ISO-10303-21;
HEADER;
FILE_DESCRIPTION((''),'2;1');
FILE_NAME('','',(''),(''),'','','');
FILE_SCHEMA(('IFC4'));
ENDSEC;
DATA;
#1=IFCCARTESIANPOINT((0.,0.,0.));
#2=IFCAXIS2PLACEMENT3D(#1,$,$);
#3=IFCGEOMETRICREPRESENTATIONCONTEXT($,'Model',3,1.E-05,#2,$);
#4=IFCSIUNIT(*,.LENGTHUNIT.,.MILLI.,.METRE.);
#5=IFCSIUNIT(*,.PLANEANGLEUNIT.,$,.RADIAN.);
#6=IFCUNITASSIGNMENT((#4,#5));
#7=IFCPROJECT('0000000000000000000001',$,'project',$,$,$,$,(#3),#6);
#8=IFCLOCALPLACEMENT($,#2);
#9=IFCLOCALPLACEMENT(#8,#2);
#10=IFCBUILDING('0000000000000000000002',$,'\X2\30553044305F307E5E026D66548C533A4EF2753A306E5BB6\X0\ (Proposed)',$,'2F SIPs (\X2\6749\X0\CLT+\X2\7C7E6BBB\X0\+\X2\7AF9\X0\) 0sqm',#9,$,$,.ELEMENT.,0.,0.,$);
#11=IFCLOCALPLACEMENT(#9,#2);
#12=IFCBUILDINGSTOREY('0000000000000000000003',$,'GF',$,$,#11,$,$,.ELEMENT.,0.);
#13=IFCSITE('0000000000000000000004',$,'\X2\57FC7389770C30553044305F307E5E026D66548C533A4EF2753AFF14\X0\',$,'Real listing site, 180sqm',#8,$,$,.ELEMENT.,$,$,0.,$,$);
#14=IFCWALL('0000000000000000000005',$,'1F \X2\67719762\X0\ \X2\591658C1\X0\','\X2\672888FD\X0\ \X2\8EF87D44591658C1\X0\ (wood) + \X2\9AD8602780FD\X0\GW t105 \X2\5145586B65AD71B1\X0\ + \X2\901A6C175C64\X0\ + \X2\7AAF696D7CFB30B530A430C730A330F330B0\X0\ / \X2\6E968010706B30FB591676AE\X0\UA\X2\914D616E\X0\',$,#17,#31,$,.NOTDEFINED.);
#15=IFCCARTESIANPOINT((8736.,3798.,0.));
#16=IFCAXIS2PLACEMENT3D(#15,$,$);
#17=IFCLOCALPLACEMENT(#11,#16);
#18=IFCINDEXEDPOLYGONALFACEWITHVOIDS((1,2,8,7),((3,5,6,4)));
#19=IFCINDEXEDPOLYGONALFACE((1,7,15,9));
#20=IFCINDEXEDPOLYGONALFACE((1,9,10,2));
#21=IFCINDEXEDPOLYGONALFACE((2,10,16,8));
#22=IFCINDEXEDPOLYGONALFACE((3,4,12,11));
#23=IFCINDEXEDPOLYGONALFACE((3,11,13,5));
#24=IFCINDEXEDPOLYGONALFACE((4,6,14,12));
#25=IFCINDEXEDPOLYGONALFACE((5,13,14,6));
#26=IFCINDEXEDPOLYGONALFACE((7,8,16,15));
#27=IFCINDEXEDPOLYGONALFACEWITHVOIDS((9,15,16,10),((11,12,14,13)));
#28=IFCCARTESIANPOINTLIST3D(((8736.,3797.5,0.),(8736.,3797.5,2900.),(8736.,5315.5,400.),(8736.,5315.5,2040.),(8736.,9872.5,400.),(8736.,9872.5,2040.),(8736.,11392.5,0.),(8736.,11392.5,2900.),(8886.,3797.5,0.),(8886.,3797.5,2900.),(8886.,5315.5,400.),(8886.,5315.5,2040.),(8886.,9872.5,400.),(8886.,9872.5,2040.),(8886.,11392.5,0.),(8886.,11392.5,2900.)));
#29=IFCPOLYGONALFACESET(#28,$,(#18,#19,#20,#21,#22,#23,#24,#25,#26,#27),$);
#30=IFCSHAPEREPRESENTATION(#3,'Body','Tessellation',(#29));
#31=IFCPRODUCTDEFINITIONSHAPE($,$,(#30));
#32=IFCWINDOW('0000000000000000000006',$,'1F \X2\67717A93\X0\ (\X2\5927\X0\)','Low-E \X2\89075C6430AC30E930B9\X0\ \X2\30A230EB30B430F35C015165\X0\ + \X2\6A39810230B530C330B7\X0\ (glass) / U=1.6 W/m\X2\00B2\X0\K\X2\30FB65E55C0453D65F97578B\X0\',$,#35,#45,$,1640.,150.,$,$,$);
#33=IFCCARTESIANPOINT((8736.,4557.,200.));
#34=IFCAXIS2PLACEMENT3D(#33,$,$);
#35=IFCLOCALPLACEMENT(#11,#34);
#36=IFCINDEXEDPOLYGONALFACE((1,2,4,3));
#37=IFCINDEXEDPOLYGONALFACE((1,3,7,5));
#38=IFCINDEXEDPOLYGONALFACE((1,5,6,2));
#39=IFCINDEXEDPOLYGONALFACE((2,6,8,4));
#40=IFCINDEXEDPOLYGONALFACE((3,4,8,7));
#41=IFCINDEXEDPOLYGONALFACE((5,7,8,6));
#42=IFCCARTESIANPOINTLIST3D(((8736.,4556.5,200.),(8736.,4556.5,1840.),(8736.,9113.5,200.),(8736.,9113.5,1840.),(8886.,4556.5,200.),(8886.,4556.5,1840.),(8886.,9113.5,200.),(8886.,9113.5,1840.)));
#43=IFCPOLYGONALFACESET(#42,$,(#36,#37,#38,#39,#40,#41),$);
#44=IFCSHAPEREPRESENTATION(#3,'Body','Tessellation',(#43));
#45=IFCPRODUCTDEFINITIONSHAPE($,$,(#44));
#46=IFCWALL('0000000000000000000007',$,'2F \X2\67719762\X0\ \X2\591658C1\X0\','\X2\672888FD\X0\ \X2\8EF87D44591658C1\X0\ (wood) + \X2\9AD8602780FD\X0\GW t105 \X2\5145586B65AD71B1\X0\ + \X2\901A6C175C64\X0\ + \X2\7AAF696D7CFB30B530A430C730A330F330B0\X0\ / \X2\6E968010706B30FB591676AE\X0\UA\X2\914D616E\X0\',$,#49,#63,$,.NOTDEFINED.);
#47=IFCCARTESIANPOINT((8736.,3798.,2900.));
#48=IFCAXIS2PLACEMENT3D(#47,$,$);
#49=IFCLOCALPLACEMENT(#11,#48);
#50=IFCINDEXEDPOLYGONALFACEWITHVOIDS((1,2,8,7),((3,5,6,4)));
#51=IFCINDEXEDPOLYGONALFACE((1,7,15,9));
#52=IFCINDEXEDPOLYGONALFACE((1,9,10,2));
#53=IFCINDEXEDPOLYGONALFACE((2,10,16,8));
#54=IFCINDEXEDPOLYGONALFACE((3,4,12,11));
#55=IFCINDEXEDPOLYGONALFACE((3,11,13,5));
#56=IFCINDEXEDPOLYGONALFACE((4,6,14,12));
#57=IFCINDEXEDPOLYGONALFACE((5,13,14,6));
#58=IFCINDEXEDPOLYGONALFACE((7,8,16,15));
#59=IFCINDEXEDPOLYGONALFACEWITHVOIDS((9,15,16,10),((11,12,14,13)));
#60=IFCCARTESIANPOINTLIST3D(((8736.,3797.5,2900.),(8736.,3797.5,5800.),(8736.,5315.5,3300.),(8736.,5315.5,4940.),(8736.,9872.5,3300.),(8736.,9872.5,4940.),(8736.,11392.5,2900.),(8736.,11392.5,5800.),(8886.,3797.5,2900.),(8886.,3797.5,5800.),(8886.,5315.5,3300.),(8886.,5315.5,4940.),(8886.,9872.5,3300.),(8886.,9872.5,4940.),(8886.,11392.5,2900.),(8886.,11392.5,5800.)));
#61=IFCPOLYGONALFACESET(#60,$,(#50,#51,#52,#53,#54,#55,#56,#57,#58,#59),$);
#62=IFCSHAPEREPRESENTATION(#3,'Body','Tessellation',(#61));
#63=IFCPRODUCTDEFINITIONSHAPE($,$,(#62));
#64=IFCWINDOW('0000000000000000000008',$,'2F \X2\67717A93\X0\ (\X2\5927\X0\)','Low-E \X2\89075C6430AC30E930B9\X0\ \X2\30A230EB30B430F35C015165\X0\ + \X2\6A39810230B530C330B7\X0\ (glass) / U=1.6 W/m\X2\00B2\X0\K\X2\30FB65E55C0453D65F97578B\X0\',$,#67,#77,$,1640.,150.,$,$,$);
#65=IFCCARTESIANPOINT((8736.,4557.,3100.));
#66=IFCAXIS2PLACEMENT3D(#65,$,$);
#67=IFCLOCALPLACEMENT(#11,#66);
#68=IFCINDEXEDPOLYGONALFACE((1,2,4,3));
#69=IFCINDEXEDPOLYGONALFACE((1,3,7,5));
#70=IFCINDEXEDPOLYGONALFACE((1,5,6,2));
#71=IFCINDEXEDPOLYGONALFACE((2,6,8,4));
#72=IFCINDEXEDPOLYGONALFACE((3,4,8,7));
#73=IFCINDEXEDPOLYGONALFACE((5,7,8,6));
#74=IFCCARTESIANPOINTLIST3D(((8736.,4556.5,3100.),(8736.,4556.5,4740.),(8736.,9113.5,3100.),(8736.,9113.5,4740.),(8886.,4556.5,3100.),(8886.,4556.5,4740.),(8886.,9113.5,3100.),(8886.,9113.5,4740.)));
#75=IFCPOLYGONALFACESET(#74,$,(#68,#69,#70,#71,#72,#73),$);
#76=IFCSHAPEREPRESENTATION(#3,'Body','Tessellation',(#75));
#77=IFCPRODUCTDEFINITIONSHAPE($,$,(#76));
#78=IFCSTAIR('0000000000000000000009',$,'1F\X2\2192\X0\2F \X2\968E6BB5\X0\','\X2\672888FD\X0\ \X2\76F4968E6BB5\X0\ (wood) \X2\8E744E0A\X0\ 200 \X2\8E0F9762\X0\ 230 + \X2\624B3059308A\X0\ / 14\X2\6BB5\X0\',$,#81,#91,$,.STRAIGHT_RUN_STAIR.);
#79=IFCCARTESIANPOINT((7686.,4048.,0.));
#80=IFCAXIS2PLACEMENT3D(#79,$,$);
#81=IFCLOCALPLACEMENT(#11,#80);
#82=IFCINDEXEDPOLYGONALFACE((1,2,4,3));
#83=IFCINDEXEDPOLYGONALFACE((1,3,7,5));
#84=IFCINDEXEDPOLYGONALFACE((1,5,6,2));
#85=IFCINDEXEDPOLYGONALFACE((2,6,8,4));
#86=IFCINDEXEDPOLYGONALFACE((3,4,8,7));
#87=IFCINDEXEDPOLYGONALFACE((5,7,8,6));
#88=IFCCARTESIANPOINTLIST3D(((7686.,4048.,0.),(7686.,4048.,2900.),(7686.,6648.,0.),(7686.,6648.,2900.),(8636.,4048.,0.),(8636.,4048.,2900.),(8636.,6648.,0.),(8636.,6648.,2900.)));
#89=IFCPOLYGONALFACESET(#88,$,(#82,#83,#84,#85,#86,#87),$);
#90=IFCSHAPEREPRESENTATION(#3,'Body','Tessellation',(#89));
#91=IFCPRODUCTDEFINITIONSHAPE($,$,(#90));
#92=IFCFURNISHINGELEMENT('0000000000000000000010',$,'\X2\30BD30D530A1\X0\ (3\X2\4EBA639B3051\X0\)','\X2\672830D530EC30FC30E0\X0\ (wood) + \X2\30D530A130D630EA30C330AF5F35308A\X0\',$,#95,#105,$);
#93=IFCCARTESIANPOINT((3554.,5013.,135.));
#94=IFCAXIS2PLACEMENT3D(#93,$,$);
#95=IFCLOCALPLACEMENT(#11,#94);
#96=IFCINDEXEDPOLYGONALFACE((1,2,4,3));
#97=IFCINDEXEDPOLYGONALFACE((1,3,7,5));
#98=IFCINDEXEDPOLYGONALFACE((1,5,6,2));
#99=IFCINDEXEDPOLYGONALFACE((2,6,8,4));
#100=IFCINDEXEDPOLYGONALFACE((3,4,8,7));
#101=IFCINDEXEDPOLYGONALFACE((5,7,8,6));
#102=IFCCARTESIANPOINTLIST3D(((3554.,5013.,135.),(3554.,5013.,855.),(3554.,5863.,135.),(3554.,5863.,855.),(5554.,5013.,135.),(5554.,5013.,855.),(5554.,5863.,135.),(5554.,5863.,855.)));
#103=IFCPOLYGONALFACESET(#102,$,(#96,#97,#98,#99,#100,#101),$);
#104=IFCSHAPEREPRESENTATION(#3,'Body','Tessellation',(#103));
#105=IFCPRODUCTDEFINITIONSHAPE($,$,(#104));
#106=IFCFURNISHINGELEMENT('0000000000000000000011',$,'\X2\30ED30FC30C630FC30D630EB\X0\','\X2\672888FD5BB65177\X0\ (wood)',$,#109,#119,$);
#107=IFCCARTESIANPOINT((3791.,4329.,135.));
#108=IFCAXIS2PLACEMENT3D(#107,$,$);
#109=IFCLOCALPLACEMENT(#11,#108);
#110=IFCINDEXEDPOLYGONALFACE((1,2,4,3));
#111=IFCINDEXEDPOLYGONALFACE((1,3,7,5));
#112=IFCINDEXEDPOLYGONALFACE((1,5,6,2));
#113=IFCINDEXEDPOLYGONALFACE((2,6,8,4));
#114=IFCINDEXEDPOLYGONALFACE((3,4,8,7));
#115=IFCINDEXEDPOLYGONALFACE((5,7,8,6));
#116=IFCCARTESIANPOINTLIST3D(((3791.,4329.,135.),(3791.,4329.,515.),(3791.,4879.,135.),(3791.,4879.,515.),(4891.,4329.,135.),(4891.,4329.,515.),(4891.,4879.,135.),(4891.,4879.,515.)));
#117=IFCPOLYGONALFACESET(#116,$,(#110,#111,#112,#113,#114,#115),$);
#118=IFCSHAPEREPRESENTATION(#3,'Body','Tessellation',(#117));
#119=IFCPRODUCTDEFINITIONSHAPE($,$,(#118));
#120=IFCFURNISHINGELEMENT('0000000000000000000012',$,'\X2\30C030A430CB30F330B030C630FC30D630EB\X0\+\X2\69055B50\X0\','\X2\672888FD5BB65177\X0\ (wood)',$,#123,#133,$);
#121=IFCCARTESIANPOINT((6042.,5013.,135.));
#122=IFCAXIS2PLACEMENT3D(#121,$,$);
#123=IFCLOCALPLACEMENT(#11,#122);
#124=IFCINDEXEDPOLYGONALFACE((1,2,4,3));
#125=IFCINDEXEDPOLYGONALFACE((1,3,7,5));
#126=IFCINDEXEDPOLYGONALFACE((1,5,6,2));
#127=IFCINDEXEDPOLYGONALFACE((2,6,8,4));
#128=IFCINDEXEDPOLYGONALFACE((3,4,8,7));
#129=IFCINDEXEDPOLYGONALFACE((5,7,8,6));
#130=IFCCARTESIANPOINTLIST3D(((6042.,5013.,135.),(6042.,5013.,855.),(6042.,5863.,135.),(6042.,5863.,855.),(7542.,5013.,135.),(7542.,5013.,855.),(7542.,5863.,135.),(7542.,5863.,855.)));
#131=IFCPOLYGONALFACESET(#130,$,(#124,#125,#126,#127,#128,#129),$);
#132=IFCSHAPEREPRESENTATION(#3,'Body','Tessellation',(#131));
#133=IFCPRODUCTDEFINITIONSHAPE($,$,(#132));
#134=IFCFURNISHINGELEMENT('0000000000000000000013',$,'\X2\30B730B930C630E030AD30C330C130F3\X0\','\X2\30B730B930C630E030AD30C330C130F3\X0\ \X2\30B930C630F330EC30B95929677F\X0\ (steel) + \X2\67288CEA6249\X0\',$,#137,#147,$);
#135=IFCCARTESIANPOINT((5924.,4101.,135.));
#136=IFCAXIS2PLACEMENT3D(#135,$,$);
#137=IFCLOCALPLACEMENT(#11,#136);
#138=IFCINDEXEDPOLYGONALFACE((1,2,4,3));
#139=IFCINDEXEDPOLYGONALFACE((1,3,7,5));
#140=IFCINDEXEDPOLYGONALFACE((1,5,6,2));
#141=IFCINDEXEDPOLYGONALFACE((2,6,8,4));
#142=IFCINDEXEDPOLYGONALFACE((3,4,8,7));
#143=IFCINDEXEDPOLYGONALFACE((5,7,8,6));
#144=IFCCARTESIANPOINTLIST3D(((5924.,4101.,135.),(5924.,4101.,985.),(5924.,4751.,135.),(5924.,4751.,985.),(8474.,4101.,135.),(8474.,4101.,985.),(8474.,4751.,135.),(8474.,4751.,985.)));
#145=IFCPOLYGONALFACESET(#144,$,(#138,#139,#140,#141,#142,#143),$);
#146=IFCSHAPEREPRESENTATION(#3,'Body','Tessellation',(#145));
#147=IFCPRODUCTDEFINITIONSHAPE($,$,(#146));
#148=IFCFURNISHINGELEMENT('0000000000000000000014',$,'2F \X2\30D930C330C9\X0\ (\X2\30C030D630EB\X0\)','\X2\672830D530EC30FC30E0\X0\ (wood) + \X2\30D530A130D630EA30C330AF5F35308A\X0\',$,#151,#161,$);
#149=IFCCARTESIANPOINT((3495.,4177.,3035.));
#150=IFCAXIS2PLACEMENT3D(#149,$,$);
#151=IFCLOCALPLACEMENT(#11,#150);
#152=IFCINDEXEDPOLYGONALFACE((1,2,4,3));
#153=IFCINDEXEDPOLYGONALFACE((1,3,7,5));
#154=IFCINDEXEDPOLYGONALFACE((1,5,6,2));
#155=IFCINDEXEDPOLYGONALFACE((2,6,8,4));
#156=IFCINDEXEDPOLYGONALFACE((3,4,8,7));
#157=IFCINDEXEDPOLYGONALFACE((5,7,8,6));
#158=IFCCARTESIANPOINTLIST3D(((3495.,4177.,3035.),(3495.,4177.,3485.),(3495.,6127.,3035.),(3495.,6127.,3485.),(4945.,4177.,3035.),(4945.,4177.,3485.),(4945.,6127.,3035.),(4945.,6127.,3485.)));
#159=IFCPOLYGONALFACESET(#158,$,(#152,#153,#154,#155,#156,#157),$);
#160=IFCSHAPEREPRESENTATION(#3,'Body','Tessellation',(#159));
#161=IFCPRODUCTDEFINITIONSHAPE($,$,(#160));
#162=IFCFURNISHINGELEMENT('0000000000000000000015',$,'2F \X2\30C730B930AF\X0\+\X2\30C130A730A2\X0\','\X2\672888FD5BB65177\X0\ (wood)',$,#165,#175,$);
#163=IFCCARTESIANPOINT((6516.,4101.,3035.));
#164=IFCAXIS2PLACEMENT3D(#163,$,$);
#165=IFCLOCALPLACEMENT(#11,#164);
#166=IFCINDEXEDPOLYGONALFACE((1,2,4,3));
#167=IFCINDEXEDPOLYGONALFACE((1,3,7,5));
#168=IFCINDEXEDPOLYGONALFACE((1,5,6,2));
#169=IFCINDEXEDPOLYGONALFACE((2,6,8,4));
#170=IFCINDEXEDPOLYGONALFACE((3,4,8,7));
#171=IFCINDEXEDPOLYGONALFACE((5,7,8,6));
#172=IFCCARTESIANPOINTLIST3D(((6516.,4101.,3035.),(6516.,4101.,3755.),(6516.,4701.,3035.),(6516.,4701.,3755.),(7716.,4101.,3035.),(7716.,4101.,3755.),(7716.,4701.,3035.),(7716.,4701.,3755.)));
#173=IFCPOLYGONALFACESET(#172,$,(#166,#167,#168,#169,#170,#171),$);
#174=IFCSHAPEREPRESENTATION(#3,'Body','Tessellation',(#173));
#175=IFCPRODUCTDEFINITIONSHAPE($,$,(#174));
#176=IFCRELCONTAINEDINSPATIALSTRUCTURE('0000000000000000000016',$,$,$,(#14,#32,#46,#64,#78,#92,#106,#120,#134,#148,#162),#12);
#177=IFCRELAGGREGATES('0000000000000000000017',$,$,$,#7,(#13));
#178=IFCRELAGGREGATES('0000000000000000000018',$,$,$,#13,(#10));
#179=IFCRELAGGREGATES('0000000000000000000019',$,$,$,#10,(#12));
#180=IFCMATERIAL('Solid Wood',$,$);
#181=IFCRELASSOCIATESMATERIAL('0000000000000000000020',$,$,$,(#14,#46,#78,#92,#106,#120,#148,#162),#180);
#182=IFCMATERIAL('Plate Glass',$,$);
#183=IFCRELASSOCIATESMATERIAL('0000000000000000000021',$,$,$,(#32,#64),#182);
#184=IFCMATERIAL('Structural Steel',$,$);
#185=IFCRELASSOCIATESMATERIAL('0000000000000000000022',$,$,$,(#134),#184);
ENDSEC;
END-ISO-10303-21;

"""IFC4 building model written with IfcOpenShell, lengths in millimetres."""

from ifc_helpers import new_model, si_unit, frame, frame_2d, origin, place, context, project, spatial, rectangle, extrude, material, element, fill, save


model = new_model("IFC4")

# Units and contexts
model_context = context("Model", 3, precision=1e-05, world=origin())
ifc_project = project(units=[si_unit("LENGTHUNIT", "METRE", prefix="MILLI"), si_unit("PLANEANGLEUNIT", "RADIAN")], contexts=[model_context])

# Site, building, storey
site_placement = place(None, origin())
site = spatial("IfcSite", under=ifc_project, at=site_placement, Name="埼玉県さいたま市浦和区仲町４", ObjectType="Real listing site, 180sqm", CompositionType="ELEMENT", RefElevation=0.0)
building_placement = place(site_placement, origin())
building = spatial("IfcBuilding", under=site, at=building_placement, Name="さいたま市浦和区仲町の家 (Proposed)", ObjectType="2F SIPs (杉CLT+籾殻+竹) 0sqm", CompositionType="ELEMENT", ElevationOfRefHeight=0.0, ElevationOfTerrain=0.0)
storey_placement = place(building_placement, origin())
storey = spatial("IfcBuildingStorey", under=building, at=storey_placement, Name="GF", CompositionType="ELEMENT", Elevation=0.0)

# Wall, opening, window
ifc_material_1 = material(Name="Solid Wood")
wall_1_placement = place(storey_placement, frame((8736.0, 3798.0, 0.0)))
wall_1 = element("IfcWall", 1, at=wall_1_placement, inside=storey, material=ifc_material_1, Name="1F 東面 外壁", Description="木製 軸組外壁 (wood) + 高性能GW t105 充填断熱 + 通気層 + 窯業系サイディング / 準耐火・外皮UA配慮", PredefinedType="NOTDEFINED", context=model_context, shape_type="SweptSolid", body=[
    extrude(rectangle(XDim=150.0, YDim=7595.0, at=frame_2d((75.0, 3797.0))), frame((8736.0, 3798.0, 0.0)), (0.0, 0.0, 1.0), 2900.0),
])
opening_1_placement = place(storey_placement, frame((8736.0, 4557.0, 200.0)))
opening_1 = element("IfcOpeningElement", 2, at=opening_1_placement, cuts=wall_1, PredefinedType="NOTDEFINED", context=model_context, shape_type="SweptSolid", body=[
    extrude(rectangle(XDim=150.0, YDim=4557.0, at=frame_2d((75.0, 2278.0))), frame((8736.0, 4557.0, 200.0)), (0.0, 0.0, 1.0), 1640.0),
])
ifc_material_2 = material(Name="Plate Glass")
window_1_placement = place(storey_placement, frame((8736.0, 4557.0, 200.0)))
window_1 = element("IfcWindow", 3, at=window_1_placement, inside=storey, material=ifc_material_2, Name="1F 東窓 (大)", Description="Low-E 複層ガラス アルゴン封入 + 樹脂サッシ (glass) / U=1.6 W/m²K・日射取得型", OverallHeight=1640.0, OverallWidth=150.0, context=model_context, shape_type="SweptSolid", body=[
    extrude(rectangle(XDim=150.0, YDim=4557.0, at=frame_2d((75.0, 2278.0))), frame((8736.0, 4557.0, 200.0)), (0.0, 0.0, 1.0), 1640.0),
])
fill(opening_1, window_1)

# Wall, opening, window
wall_2_placement = place(storey_placement, frame((8736.0, 3798.0, 2900.0)))
wall_2 = element("IfcWall", 4, at=wall_2_placement, inside=storey, material=ifc_material_1, Name="2F 東面 外壁", Description="木製 軸組外壁 (wood) + 高性能GW t105 充填断熱 + 通気層 + 窯業系サイディング / 準耐火・外皮UA配慮", PredefinedType="NOTDEFINED", context=model_context, shape_type="SweptSolid", body=[
    extrude(rectangle(XDim=150.0, YDim=7595.0, at=frame_2d((75.0, 3797.0))), frame((8736.0, 3798.0, 2900.0)), (0.0, 0.0, 1.0), 2900.0),
])
opening_2_placement = place(storey_placement, frame((8736.0, 4557.0, 3100.0)))
opening_2 = element("IfcOpeningElement", 5, at=opening_2_placement, cuts=wall_2, PredefinedType="NOTDEFINED", context=model_context, shape_type="SweptSolid", body=[
    extrude(rectangle(XDim=150.0, YDim=4557.0, at=frame_2d((75.0, 2278.0))), frame((8736.0, 4557.0, 3100.0)), (0.0, 0.0, 1.0), 1640.0),
])
window_2_placement = place(storey_placement, frame((8736.0, 4557.0, 3100.0)))
window_2 = element("IfcWindow", 6, at=window_2_placement, inside=storey, material=ifc_material_2, Name="2F 東窓 (大)", Description="Low-E 複層ガラス アルゴン封入 + 樹脂サッシ (glass) / U=1.6 W/m²K・日射取得型", OverallHeight=1640.0, OverallWidth=150.0, context=model_context, shape_type="SweptSolid", body=[
    extrude(rectangle(XDim=150.0, YDim=4557.0, at=frame_2d((75.0, 2278.0))), frame((8736.0, 4557.0, 3100.0)), (0.0, 0.0, 1.0), 1640.0),
])
fill(opening_2, window_2)

# Stair
stair_placement = place(storey_placement, frame((7686.0, 4048.0, 0.0)))
element("IfcStair", 7, at=stair_placement, inside=storey, material=ifc_material_1, Name="1F→2F 階段", Description="木製 直階段 (wood) 蹴上 200 踏面 230 + 手すり / 14段", PredefinedType="STRAIGHT_RUN_STAIR", context=model_context, shape_type="SweptSolid", body=[
    extrude(rectangle(XDim=950.0, YDim=2600.0, at=frame_2d((475.0, 1300.0))), frame((7686.0, 4048.0, 0.0)), (0.0, 0.0, 1.0), 2900.0),
])

# Furnishing elements
furnishing_1_placement = place(storey_placement, frame((3554.0, 5013.0, 135.0)))
element("IfcFurnishingElement", 8, at=furnishing_1_placement, inside=storey, material=ifc_material_1, Name="ソファ (3人掛け)", Description="木フレーム (wood) + ファブリック張り", context=model_context, shape_type="SweptSolid", body=[
    extrude(rectangle(XDim=2000.0, YDim=850.0, at=frame_2d((1000.0, 425.0))), frame((3554.0, 5013.0, 135.0)), (0.0, 0.0, 1.0), 720.0),
])
furnishing_2_placement = place(storey_placement, frame((3791.0, 4329.0, 135.0)))
element("IfcFurnishingElement", 9, at=furnishing_2_placement, inside=storey, material=ifc_material_1, Name="ローテーブル", Description="木製家具 (wood)", context=model_context, shape_type="SweptSolid", body=[
    extrude(rectangle(XDim=1100.0, YDim=550.0, at=frame_2d((550.0, 275.0))), frame((3791.0, 4329.0, 135.0)), (0.0, 0.0, 1.0), 380.0),
])
furnishing_3_placement = place(storey_placement, frame((6042.0, 5013.0, 135.0)))
element("IfcFurnishingElement", 10, at=furnishing_3_placement, inside=storey, material=ifc_material_1, Name="ダイニングテーブル+椅子", Description="木製家具 (wood)", context=model_context, shape_type="SweptSolid", body=[
    extrude(rectangle(XDim=1500.0, YDim=850.0, at=frame_2d((750.0, 425.0))), frame((6042.0, 5013.0, 135.0)), (0.0, 0.0, 1.0), 720.0),
])
ifc_material_3 = material(Name="Structural Steel")
furnishing_4_placement = place(storey_placement, frame((5924.0, 4101.0, 135.0)))
element("IfcFurnishingElement", 11, at=furnishing_4_placement, inside=storey, material=ifc_material_3, Name="システムキッチン", Description="システムキッチン ステンレス天板 (steel) + 木質扉", context=model_context, shape_type="SweptSolid", body=[
    extrude(rectangle(XDim=2550.0, YDim=650.0, at=frame_2d((1275.0, 325.0))), frame((5924.0, 4101.0, 135.0)), (0.0, 0.0, 1.0), 850.0),
])
furnishing_5_placement = place(storey_placement, frame((3495.0, 4177.0, 3035.0)))
element("IfcFurnishingElement", 12, at=furnishing_5_placement, inside=storey, material=ifc_material_1, Name="2F ベッド (ダブル)", Description="木フレーム (wood) + ファブリック張り", context=model_context, shape_type="SweptSolid", body=[
    extrude(rectangle(XDim=1450.0, YDim=1950.0, at=frame_2d((725.0, 975.0))), frame((3495.0, 4177.0, 3035.0)), (0.0, 0.0, 1.0), 450.0),
])
furnishing_6_placement = place(storey_placement, frame((6516.0, 4101.0, 3035.0)))
element("IfcFurnishingElement", 13, at=furnishing_6_placement, inside=storey, material=ifc_material_1, Name="2F デスク+チェア", Description="木製家具 (wood)", context=model_context, shape_type="SweptSolid", body=[
    extrude(rectangle(XDim=1200.0, YDim=600.0, at=frame_2d((600.0, 300.0))), frame((6516.0, 4101.0, 3035.0)), (0.0, 0.0, 1.0), 720.0),
])

save(model, "model.ifc")
